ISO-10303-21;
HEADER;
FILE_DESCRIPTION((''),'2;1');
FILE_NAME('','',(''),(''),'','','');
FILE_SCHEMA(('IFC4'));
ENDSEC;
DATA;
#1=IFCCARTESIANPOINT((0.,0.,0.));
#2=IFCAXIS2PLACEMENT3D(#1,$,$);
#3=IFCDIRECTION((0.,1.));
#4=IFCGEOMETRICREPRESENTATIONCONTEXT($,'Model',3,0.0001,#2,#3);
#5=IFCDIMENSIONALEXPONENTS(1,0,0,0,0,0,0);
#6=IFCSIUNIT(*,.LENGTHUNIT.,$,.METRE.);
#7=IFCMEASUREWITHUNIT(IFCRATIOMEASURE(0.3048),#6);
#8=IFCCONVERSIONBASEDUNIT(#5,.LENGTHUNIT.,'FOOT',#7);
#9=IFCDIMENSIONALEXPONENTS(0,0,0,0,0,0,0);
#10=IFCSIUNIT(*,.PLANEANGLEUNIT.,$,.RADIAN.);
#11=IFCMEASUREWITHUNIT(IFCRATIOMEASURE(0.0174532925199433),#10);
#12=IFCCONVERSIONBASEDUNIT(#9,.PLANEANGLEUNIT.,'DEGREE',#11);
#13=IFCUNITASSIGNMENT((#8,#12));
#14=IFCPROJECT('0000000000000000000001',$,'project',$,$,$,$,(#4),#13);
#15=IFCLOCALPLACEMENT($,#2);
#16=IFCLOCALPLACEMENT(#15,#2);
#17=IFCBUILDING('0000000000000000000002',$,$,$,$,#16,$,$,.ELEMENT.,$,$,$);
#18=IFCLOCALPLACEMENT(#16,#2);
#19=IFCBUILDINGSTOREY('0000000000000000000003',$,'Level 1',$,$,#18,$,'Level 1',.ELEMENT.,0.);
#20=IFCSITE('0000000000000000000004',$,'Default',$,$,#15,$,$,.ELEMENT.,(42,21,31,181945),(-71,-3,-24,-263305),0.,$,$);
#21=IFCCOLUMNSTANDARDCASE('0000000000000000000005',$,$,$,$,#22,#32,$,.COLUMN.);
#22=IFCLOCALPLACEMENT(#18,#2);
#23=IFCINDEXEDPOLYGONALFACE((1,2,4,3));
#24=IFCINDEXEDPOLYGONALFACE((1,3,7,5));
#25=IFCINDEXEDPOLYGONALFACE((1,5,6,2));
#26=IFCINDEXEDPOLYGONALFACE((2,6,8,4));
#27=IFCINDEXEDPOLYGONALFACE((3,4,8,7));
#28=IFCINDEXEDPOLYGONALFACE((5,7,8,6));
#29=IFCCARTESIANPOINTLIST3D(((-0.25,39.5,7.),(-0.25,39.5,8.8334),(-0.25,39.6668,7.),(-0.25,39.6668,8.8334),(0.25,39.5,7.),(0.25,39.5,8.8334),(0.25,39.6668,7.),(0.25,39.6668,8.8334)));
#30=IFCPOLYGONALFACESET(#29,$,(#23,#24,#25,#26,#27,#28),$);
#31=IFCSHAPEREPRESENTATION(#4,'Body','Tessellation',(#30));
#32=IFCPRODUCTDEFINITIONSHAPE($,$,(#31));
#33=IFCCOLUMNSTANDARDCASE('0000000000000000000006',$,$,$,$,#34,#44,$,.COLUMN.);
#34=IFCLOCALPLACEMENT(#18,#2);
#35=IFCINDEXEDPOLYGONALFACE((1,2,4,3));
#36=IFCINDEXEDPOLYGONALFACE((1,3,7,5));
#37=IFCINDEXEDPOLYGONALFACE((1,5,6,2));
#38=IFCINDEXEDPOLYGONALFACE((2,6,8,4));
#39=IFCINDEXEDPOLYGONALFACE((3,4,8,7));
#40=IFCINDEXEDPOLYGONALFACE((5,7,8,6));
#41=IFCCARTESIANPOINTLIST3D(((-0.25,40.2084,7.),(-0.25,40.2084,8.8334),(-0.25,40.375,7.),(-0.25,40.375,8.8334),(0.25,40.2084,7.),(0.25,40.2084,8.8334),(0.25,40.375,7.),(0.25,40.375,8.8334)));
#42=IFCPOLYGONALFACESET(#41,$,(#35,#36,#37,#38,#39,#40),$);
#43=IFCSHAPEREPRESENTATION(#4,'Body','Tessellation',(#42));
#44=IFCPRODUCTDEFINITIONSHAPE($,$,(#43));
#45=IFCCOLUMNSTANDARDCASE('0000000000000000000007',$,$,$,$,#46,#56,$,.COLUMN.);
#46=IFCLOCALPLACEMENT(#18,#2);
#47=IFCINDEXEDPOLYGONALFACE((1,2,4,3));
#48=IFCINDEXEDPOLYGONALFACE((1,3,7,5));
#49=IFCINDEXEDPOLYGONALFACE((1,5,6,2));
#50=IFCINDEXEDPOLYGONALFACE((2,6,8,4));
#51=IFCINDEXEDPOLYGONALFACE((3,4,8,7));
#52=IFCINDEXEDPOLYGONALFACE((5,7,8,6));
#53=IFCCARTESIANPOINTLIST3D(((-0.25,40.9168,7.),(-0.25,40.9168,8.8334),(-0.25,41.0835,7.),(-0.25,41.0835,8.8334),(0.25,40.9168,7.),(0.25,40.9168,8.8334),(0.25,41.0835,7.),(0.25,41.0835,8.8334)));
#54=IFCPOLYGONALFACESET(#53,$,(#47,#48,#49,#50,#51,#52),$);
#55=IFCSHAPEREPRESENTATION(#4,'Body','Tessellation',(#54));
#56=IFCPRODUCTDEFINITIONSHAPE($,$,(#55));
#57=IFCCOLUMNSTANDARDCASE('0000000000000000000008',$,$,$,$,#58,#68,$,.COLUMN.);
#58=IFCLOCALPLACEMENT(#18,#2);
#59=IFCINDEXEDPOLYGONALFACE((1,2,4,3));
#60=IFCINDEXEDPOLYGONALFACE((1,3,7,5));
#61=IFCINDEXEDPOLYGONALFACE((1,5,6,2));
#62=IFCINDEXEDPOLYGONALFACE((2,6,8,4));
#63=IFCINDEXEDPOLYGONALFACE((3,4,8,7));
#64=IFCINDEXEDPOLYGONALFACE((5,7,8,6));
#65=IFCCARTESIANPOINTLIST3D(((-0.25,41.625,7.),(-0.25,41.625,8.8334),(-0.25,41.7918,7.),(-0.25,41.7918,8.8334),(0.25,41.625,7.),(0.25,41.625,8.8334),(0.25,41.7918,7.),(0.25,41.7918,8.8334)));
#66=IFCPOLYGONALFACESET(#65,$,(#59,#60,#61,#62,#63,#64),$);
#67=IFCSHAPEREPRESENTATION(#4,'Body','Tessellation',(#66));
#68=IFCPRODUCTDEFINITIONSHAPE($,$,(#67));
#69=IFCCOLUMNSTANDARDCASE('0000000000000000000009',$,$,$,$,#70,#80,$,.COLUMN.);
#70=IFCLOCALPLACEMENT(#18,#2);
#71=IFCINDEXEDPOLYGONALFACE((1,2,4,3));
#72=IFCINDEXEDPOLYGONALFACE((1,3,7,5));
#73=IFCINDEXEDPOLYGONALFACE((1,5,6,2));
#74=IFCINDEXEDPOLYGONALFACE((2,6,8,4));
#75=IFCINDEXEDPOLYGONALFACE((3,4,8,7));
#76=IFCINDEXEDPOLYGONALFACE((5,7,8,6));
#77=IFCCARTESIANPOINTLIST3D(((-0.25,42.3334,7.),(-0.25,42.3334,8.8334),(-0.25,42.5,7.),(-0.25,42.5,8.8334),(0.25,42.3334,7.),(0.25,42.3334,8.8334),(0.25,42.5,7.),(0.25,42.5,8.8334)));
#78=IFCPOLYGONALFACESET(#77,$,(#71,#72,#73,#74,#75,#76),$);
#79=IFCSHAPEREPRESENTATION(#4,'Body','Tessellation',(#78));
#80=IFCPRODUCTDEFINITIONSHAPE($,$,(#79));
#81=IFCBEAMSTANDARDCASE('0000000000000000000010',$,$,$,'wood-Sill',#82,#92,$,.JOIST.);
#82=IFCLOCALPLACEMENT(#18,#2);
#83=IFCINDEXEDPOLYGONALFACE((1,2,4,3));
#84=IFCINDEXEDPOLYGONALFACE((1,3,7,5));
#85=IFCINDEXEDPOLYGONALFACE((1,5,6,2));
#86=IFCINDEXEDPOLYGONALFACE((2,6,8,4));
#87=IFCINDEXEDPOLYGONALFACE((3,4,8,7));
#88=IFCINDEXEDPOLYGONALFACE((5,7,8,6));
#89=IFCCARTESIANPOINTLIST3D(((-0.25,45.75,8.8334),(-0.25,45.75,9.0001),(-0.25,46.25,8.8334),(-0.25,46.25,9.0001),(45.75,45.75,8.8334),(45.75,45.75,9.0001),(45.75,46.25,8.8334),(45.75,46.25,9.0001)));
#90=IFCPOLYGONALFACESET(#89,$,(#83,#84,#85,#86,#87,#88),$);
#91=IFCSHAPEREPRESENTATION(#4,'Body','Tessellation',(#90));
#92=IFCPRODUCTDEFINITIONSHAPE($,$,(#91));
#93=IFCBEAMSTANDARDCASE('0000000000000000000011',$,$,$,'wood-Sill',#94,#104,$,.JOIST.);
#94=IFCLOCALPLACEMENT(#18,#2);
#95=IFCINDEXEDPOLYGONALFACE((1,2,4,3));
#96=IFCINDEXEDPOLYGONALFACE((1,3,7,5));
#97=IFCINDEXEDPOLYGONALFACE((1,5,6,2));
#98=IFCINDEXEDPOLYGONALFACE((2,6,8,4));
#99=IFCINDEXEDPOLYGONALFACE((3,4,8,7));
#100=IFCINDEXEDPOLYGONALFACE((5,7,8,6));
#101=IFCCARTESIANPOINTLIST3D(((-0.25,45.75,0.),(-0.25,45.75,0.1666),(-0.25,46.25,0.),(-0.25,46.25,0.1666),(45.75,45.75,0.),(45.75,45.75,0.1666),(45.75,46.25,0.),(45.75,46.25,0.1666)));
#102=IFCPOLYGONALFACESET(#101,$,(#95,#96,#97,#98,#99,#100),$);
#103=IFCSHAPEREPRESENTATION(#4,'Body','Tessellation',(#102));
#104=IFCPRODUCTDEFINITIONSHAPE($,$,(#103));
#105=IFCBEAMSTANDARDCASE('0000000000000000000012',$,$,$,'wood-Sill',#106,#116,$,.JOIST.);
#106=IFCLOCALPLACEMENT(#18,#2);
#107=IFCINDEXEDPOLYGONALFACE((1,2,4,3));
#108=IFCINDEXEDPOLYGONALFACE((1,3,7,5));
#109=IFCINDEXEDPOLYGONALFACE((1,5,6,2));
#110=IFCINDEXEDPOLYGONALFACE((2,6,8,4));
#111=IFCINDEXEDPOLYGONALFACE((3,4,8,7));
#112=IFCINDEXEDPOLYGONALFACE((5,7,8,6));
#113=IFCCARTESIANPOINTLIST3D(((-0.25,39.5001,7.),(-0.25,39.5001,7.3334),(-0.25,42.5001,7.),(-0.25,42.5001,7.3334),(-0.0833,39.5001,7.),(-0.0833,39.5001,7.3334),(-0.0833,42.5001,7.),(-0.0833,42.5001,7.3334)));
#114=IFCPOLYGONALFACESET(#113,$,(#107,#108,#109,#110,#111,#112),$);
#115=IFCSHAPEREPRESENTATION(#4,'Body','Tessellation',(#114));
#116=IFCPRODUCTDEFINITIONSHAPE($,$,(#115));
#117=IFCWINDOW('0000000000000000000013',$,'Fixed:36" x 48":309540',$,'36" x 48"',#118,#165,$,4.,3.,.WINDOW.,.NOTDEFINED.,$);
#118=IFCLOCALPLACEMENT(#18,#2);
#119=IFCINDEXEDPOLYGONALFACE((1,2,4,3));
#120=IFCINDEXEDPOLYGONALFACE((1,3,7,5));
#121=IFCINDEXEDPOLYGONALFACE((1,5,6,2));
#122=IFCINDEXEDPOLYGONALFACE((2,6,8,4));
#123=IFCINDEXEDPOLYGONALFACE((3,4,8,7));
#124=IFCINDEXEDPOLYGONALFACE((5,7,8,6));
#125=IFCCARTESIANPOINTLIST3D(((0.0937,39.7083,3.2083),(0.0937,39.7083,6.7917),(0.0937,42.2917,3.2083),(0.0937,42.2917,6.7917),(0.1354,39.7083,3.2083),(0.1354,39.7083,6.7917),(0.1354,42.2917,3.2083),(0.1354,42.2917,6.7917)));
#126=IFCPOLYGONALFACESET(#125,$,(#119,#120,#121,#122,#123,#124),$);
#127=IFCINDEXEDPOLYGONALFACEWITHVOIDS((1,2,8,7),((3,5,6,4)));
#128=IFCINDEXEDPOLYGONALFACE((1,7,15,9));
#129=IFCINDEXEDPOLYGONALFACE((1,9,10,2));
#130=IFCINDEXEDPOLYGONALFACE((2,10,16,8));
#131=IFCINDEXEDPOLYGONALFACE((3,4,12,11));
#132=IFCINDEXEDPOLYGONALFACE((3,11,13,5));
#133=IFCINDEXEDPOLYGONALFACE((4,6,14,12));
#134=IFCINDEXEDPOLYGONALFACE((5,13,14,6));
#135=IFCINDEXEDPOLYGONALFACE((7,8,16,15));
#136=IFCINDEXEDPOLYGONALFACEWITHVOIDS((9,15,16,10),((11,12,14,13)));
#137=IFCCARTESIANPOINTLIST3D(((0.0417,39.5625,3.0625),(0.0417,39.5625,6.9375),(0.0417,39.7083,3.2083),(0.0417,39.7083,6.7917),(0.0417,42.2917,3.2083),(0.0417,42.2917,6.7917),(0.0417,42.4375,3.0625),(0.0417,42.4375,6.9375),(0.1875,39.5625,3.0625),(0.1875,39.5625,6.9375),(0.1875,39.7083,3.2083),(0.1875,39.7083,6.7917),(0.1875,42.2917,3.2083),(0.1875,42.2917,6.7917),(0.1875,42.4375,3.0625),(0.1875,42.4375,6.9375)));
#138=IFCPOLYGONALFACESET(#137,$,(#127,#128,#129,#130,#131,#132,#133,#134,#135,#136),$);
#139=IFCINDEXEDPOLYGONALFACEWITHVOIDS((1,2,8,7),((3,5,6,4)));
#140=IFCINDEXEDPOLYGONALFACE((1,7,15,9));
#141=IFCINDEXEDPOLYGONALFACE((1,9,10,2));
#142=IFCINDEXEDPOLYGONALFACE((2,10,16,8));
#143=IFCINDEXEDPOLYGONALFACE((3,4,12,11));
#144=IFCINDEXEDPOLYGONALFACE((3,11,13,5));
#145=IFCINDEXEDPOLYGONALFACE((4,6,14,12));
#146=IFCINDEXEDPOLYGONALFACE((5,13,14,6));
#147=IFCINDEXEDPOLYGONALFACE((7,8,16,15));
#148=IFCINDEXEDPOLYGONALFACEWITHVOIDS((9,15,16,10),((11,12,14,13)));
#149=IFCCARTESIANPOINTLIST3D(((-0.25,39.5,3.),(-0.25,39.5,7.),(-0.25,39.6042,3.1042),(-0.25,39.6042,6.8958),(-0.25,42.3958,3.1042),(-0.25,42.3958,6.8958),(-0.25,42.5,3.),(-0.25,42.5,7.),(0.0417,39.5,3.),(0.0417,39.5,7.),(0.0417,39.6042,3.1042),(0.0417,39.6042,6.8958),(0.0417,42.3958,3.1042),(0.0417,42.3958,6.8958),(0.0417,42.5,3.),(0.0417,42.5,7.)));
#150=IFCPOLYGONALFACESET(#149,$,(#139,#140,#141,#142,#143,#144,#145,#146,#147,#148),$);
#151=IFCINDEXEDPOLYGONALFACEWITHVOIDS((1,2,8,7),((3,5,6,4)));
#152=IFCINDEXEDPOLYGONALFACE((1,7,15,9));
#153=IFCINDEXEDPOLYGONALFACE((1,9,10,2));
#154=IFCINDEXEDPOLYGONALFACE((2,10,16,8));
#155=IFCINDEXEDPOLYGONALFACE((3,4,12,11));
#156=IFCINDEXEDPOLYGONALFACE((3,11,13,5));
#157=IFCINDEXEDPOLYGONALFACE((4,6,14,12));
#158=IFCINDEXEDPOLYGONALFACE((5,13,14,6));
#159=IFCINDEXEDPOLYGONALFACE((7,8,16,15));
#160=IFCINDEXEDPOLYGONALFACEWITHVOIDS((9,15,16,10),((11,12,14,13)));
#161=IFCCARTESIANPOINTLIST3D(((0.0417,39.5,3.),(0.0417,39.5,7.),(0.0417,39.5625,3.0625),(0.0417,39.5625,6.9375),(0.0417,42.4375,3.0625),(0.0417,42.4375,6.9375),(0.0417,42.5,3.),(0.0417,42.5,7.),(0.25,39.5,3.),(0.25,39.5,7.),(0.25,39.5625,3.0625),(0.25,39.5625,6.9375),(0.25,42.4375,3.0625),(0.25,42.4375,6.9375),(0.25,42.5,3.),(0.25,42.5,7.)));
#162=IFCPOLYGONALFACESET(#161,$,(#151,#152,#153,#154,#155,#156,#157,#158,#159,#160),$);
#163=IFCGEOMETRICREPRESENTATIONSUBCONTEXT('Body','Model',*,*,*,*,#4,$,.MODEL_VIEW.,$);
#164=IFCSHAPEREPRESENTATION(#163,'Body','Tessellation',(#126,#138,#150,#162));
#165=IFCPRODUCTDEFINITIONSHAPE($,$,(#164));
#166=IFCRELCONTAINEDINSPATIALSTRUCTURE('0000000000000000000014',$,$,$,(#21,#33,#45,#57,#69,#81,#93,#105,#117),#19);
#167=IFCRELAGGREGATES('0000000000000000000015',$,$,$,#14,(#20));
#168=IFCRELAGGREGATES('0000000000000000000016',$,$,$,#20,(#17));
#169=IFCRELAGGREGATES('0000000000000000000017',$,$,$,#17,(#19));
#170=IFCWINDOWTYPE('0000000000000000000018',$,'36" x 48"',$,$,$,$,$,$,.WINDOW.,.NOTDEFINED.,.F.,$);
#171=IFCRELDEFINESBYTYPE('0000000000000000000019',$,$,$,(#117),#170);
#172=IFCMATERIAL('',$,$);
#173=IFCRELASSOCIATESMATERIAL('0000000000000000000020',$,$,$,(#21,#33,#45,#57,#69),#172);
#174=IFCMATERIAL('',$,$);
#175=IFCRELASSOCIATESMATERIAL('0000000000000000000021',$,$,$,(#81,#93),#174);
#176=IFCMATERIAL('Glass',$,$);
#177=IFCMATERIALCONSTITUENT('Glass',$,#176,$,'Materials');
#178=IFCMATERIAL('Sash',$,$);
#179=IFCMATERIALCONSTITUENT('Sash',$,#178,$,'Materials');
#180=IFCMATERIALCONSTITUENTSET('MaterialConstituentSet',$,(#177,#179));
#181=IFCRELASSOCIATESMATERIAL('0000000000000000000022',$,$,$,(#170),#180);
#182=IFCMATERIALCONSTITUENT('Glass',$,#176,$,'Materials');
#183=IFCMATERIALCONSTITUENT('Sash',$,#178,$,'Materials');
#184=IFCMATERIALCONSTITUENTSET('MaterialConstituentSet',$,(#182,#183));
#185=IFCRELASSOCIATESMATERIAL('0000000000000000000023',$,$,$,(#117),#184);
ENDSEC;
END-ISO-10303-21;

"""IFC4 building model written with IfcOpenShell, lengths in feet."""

from ifc_helpers import new_model, entity, si_unit, converted_unit, direction, frame, frame_2d, origin, origin_with_axes, place, context, subcontext, project, spatial, polyline, rectangle, outline, extrude, source, transform, mapped, material, constituent, constituent_set, type_object, type_shapes, element, save


model = new_model("IFC4")

# Units and contexts
model_context = context("Model", 3, precision=0.0001, world=origin(), true_north=direction((0.0, 1.0)))
body_context = subcontext(model_context, "Body", "Model", "MODEL_VIEW")
ifc_project = project(units=[converted_unit("LENGTHUNIT", "FOOT", entity("IfcRatioMeasure", 0.3048), si_unit("LENGTHUNIT", "METRE"), dimensions=[1, 0, 0, 0, 0, 0, 0]), converted_unit("PLANEANGLEUNIT", "DEGREE", entity("IfcRatioMeasure", 0.0174532925199433), si_unit("PLANEANGLEUNIT", "RADIAN"), dimensions=[0, 0, 0, 0, 0, 0, 0])], contexts=[model_context])

# Site, building, storey
site_placement = place(None, origin())
site = spatial("IfcSite", under=ifc_project, at=site_placement, Name="Default", CompositionType="ELEMENT", RefLatitude=(42, 21, 31, 181945), RefLongitude=(-71, -3, -24, -263305), RefElevation=0.0)
building_placement = place(site_placement, origin())
building = spatial("IfcBuilding", under=site, at=building_placement, CompositionType="ELEMENT")
storey_placement = place(building_placement, origin())
storey = spatial("IfcBuildingStorey", under=building, at=storey_placement, Name="Level 1", LongName="Level 1", CompositionType="ELEMENT", Elevation=0.0)

# Columns
placement_1 = place(storey_placement, frame((-0.25, 46.0, 0.0)))
placement_2 = place(storey_placement, frame((0.0, -0.25, 0.0), z_axis=(0.0, 0.0, 1.0), x_axis=(0.0, 1.0, 0.0)))
ifc_material_1 = material(Name="")
for number, where, z_axis, x_axis in (
    (1, (39.8334, 0.0, 7.0), (0.0, 0.0, 1.0), (1.0, 0.0, 0.0)),
    (2, (40.5417, 0.0, 7.0), (0.0, 0.0, 1.0), (1.0, 0.0, 0.0)),
    (3, (41.2501, 0.0, 7.0), (0.0, 0.0, 1.0), (1.0, 0.0, 0.0)),
    (4, (41.9584, 0.0, 7.0), (0.0, 0.0, 1.0), (1.0, 0.0, 0.0)),
    (5, (42.6667, 0.0, 7.0), (0.0, 0.0, 1.0), (1.0, 0.0, 0.0)),
):
    element("IfcColumnStandardCase", number, at=place(placement_2, frame(where, z_axis=z_axis, x_axis=x_axis)), inside=storey, material=ifc_material_1, PredefinedType="COLUMN", context=model_context, shape_type="SweptSolid", body=[
        extrude(rectangle(XDim=0.1667, YDim=0.5), origin(), (0.0, 0.0, 1.0), 1.8334),
    ])

# Beams
ifc_material_2 = material(Name="")
for number, where, z_axis, x_axis in (
    (6, (0.0, 0.0, 8.9167), (1.0, 0.0, 0.0), (0.0, 0.0, 1.0)),
    (7, (0.0, 0.0, 0.0833), (1.0, 0.0, 0.0), (0.0, 0.0, 1.0)),
):
    element("IfcBeamStandardCase", number, at=place(placement_1, frame(where, z_axis=z_axis, x_axis=x_axis)), inside=storey, material=ifc_material_2, ObjectType="wood-Sill", PredefinedType="JOIST", context=model_context, shape_type="SweptSolid", body=[
        extrude(rectangle(XDim=0.1667, YDim=0.5), origin_with_axes(), (0.0, 0.0, 1.0), 46.0),
    ])
beam_placement = place(placement_2, frame((39.7501, 0.1667, 7.1667), z_axis=(1.0, 0.0, 0.0), x_axis=(0.0, 0.0, 1.0)))
element("IfcBeamStandardCase", 8, at=beam_placement, inside=storey, ObjectType="wood-Sill", PredefinedType="JOIST", context=model_context, shape_type="SweptSolid", body=[
    extrude(rectangle(XDim=0.3333, YDim=0.1667), origin_with_axes(), (0.0, 0.0, 1.0), 3.0),
])

# Window
ifc_material_3 = material(Name="Glass")
ifc_constituent_1 = constituent(ifc_material_3, Name="Glass", Category="Materials")
ifc_material_4 = material(Name="Sash")
ifc_constituent_2 = constituent(ifc_material_4, Name="Sash", Category="Materials")
ifc_constituent_set_1 = constituent_set(constituents=[ifc_constituent_1, ifc_constituent_2], Name="MaterialConstituentSet")
ifc_constituent_3 = constituent(ifc_material_3, Name="Glass", Category="Materials")
ifc_constituent_4 = constituent(ifc_material_4, Name="Sash", Category="Materials")
ifc_constituent_set_2 = constituent_set(constituents=[ifc_constituent_3, ifc_constituent_4], Name="MaterialConstituentSet")
window_type = type_object("IfcWindowType", Name="36\" x 48\"", ParameterTakesPrecedence=False, PartitioningType="NOTDEFINED", PredefinedType="WINDOW", material=ifc_constituent_set_2)
shared_shape = source(origin(), body_context, "Body", "SweptSolid", [
    extrude(rectangle(XDim=0.0417, YDim=2.5833, at=frame_2d((0.0, 0.0), x_axis=(1.0, 0.0))), frame((1.5, 0.3646, 0.2083), z_axis=(0.0, 0.0, 1.0), x_axis=(0.0, 1.0, 0.0)), (0.0, 0.0, 1.0), 3.5833),
    extrude(outline(polyline([(-1.4375, -1.9375), (1.4375, -1.9375), (1.4375, 1.9375), (-1.4375, 1.9375), (-1.4375, -1.9375)]), holes=[polyline([(-1.2917, -1.7917), (-1.2917, 1.7917), (1.2917, 1.7917), (1.2917, -1.7917), (-1.2917, -1.7917)])]), frame((1.5, 0.2917, 2.0), z_axis=(0.0, 1.0, 0.0), x_axis=(1.0, 0.0, 0.0)), (0.0, 0.0, 1.0), 0.1458),
    extrude(outline(polyline([(-1.5, -2.0), (1.5, -2.0), (1.5, 2.0), (-1.5, 2.0), (-1.5, -2.0)]), holes=[polyline([(-1.3958, -1.8958), (-1.3958, 1.8958), (1.3958, 1.8958), (1.3958, -1.8958), (-1.3958, -1.8958)])]), frame((1.5, 0.0, 2.0), z_axis=(0.0, 1.0, 0.0), x_axis=(1.0, 0.0, 0.0)), (0.0, 0.0, 1.0), 0.2917),
    extrude(outline(polyline([(-2.0, -1.5), (2.0, -1.5), (2.0, 1.5), (-2.0, 1.5), (-2.0, -1.5)]), holes=[polyline([(-1.9375, -1.4375), (-1.9375, 1.4375), (1.9375, 1.4375), (1.9375, -1.4375), (-1.9375, -1.4375)])]), frame((1.5, 0.2917, 2.0), z_axis=(0.0, 1.0, 0.0), x_axis=(0.0, 0.0, -1.0)), (0.0, 0.0, 1.0), 0.2083),
])
type_shapes(window_type, [shared_shape])
placement_3 = place(placement_2, frame((42.75, 0.25, 3.0)))
window_placement = place(placement_3, frame((0.0, 0.0, 0.0), z_axis=(0.0, 0.0, 1.0), x_axis=(-1.0, 0.0, 0.0)))
element("IfcWindow", 9, at=window_placement, inside=storey, type_object=window_type, material=ifc_constituent_set_1, Name="Fixed:36\" x 48\":309540", ObjectType="36\" x 48\"", OverallHeight=4.0, OverallWidth=3.0, PartitioningType="NOTDEFINED", PredefinedType="WINDOW", context=body_context, shape_type="MappedRepresentation", body=[
    mapped(shared_shape, transform((0.0, 0.0, 0.0), scale=1.0)),
])

save(model, "model.ifc")
